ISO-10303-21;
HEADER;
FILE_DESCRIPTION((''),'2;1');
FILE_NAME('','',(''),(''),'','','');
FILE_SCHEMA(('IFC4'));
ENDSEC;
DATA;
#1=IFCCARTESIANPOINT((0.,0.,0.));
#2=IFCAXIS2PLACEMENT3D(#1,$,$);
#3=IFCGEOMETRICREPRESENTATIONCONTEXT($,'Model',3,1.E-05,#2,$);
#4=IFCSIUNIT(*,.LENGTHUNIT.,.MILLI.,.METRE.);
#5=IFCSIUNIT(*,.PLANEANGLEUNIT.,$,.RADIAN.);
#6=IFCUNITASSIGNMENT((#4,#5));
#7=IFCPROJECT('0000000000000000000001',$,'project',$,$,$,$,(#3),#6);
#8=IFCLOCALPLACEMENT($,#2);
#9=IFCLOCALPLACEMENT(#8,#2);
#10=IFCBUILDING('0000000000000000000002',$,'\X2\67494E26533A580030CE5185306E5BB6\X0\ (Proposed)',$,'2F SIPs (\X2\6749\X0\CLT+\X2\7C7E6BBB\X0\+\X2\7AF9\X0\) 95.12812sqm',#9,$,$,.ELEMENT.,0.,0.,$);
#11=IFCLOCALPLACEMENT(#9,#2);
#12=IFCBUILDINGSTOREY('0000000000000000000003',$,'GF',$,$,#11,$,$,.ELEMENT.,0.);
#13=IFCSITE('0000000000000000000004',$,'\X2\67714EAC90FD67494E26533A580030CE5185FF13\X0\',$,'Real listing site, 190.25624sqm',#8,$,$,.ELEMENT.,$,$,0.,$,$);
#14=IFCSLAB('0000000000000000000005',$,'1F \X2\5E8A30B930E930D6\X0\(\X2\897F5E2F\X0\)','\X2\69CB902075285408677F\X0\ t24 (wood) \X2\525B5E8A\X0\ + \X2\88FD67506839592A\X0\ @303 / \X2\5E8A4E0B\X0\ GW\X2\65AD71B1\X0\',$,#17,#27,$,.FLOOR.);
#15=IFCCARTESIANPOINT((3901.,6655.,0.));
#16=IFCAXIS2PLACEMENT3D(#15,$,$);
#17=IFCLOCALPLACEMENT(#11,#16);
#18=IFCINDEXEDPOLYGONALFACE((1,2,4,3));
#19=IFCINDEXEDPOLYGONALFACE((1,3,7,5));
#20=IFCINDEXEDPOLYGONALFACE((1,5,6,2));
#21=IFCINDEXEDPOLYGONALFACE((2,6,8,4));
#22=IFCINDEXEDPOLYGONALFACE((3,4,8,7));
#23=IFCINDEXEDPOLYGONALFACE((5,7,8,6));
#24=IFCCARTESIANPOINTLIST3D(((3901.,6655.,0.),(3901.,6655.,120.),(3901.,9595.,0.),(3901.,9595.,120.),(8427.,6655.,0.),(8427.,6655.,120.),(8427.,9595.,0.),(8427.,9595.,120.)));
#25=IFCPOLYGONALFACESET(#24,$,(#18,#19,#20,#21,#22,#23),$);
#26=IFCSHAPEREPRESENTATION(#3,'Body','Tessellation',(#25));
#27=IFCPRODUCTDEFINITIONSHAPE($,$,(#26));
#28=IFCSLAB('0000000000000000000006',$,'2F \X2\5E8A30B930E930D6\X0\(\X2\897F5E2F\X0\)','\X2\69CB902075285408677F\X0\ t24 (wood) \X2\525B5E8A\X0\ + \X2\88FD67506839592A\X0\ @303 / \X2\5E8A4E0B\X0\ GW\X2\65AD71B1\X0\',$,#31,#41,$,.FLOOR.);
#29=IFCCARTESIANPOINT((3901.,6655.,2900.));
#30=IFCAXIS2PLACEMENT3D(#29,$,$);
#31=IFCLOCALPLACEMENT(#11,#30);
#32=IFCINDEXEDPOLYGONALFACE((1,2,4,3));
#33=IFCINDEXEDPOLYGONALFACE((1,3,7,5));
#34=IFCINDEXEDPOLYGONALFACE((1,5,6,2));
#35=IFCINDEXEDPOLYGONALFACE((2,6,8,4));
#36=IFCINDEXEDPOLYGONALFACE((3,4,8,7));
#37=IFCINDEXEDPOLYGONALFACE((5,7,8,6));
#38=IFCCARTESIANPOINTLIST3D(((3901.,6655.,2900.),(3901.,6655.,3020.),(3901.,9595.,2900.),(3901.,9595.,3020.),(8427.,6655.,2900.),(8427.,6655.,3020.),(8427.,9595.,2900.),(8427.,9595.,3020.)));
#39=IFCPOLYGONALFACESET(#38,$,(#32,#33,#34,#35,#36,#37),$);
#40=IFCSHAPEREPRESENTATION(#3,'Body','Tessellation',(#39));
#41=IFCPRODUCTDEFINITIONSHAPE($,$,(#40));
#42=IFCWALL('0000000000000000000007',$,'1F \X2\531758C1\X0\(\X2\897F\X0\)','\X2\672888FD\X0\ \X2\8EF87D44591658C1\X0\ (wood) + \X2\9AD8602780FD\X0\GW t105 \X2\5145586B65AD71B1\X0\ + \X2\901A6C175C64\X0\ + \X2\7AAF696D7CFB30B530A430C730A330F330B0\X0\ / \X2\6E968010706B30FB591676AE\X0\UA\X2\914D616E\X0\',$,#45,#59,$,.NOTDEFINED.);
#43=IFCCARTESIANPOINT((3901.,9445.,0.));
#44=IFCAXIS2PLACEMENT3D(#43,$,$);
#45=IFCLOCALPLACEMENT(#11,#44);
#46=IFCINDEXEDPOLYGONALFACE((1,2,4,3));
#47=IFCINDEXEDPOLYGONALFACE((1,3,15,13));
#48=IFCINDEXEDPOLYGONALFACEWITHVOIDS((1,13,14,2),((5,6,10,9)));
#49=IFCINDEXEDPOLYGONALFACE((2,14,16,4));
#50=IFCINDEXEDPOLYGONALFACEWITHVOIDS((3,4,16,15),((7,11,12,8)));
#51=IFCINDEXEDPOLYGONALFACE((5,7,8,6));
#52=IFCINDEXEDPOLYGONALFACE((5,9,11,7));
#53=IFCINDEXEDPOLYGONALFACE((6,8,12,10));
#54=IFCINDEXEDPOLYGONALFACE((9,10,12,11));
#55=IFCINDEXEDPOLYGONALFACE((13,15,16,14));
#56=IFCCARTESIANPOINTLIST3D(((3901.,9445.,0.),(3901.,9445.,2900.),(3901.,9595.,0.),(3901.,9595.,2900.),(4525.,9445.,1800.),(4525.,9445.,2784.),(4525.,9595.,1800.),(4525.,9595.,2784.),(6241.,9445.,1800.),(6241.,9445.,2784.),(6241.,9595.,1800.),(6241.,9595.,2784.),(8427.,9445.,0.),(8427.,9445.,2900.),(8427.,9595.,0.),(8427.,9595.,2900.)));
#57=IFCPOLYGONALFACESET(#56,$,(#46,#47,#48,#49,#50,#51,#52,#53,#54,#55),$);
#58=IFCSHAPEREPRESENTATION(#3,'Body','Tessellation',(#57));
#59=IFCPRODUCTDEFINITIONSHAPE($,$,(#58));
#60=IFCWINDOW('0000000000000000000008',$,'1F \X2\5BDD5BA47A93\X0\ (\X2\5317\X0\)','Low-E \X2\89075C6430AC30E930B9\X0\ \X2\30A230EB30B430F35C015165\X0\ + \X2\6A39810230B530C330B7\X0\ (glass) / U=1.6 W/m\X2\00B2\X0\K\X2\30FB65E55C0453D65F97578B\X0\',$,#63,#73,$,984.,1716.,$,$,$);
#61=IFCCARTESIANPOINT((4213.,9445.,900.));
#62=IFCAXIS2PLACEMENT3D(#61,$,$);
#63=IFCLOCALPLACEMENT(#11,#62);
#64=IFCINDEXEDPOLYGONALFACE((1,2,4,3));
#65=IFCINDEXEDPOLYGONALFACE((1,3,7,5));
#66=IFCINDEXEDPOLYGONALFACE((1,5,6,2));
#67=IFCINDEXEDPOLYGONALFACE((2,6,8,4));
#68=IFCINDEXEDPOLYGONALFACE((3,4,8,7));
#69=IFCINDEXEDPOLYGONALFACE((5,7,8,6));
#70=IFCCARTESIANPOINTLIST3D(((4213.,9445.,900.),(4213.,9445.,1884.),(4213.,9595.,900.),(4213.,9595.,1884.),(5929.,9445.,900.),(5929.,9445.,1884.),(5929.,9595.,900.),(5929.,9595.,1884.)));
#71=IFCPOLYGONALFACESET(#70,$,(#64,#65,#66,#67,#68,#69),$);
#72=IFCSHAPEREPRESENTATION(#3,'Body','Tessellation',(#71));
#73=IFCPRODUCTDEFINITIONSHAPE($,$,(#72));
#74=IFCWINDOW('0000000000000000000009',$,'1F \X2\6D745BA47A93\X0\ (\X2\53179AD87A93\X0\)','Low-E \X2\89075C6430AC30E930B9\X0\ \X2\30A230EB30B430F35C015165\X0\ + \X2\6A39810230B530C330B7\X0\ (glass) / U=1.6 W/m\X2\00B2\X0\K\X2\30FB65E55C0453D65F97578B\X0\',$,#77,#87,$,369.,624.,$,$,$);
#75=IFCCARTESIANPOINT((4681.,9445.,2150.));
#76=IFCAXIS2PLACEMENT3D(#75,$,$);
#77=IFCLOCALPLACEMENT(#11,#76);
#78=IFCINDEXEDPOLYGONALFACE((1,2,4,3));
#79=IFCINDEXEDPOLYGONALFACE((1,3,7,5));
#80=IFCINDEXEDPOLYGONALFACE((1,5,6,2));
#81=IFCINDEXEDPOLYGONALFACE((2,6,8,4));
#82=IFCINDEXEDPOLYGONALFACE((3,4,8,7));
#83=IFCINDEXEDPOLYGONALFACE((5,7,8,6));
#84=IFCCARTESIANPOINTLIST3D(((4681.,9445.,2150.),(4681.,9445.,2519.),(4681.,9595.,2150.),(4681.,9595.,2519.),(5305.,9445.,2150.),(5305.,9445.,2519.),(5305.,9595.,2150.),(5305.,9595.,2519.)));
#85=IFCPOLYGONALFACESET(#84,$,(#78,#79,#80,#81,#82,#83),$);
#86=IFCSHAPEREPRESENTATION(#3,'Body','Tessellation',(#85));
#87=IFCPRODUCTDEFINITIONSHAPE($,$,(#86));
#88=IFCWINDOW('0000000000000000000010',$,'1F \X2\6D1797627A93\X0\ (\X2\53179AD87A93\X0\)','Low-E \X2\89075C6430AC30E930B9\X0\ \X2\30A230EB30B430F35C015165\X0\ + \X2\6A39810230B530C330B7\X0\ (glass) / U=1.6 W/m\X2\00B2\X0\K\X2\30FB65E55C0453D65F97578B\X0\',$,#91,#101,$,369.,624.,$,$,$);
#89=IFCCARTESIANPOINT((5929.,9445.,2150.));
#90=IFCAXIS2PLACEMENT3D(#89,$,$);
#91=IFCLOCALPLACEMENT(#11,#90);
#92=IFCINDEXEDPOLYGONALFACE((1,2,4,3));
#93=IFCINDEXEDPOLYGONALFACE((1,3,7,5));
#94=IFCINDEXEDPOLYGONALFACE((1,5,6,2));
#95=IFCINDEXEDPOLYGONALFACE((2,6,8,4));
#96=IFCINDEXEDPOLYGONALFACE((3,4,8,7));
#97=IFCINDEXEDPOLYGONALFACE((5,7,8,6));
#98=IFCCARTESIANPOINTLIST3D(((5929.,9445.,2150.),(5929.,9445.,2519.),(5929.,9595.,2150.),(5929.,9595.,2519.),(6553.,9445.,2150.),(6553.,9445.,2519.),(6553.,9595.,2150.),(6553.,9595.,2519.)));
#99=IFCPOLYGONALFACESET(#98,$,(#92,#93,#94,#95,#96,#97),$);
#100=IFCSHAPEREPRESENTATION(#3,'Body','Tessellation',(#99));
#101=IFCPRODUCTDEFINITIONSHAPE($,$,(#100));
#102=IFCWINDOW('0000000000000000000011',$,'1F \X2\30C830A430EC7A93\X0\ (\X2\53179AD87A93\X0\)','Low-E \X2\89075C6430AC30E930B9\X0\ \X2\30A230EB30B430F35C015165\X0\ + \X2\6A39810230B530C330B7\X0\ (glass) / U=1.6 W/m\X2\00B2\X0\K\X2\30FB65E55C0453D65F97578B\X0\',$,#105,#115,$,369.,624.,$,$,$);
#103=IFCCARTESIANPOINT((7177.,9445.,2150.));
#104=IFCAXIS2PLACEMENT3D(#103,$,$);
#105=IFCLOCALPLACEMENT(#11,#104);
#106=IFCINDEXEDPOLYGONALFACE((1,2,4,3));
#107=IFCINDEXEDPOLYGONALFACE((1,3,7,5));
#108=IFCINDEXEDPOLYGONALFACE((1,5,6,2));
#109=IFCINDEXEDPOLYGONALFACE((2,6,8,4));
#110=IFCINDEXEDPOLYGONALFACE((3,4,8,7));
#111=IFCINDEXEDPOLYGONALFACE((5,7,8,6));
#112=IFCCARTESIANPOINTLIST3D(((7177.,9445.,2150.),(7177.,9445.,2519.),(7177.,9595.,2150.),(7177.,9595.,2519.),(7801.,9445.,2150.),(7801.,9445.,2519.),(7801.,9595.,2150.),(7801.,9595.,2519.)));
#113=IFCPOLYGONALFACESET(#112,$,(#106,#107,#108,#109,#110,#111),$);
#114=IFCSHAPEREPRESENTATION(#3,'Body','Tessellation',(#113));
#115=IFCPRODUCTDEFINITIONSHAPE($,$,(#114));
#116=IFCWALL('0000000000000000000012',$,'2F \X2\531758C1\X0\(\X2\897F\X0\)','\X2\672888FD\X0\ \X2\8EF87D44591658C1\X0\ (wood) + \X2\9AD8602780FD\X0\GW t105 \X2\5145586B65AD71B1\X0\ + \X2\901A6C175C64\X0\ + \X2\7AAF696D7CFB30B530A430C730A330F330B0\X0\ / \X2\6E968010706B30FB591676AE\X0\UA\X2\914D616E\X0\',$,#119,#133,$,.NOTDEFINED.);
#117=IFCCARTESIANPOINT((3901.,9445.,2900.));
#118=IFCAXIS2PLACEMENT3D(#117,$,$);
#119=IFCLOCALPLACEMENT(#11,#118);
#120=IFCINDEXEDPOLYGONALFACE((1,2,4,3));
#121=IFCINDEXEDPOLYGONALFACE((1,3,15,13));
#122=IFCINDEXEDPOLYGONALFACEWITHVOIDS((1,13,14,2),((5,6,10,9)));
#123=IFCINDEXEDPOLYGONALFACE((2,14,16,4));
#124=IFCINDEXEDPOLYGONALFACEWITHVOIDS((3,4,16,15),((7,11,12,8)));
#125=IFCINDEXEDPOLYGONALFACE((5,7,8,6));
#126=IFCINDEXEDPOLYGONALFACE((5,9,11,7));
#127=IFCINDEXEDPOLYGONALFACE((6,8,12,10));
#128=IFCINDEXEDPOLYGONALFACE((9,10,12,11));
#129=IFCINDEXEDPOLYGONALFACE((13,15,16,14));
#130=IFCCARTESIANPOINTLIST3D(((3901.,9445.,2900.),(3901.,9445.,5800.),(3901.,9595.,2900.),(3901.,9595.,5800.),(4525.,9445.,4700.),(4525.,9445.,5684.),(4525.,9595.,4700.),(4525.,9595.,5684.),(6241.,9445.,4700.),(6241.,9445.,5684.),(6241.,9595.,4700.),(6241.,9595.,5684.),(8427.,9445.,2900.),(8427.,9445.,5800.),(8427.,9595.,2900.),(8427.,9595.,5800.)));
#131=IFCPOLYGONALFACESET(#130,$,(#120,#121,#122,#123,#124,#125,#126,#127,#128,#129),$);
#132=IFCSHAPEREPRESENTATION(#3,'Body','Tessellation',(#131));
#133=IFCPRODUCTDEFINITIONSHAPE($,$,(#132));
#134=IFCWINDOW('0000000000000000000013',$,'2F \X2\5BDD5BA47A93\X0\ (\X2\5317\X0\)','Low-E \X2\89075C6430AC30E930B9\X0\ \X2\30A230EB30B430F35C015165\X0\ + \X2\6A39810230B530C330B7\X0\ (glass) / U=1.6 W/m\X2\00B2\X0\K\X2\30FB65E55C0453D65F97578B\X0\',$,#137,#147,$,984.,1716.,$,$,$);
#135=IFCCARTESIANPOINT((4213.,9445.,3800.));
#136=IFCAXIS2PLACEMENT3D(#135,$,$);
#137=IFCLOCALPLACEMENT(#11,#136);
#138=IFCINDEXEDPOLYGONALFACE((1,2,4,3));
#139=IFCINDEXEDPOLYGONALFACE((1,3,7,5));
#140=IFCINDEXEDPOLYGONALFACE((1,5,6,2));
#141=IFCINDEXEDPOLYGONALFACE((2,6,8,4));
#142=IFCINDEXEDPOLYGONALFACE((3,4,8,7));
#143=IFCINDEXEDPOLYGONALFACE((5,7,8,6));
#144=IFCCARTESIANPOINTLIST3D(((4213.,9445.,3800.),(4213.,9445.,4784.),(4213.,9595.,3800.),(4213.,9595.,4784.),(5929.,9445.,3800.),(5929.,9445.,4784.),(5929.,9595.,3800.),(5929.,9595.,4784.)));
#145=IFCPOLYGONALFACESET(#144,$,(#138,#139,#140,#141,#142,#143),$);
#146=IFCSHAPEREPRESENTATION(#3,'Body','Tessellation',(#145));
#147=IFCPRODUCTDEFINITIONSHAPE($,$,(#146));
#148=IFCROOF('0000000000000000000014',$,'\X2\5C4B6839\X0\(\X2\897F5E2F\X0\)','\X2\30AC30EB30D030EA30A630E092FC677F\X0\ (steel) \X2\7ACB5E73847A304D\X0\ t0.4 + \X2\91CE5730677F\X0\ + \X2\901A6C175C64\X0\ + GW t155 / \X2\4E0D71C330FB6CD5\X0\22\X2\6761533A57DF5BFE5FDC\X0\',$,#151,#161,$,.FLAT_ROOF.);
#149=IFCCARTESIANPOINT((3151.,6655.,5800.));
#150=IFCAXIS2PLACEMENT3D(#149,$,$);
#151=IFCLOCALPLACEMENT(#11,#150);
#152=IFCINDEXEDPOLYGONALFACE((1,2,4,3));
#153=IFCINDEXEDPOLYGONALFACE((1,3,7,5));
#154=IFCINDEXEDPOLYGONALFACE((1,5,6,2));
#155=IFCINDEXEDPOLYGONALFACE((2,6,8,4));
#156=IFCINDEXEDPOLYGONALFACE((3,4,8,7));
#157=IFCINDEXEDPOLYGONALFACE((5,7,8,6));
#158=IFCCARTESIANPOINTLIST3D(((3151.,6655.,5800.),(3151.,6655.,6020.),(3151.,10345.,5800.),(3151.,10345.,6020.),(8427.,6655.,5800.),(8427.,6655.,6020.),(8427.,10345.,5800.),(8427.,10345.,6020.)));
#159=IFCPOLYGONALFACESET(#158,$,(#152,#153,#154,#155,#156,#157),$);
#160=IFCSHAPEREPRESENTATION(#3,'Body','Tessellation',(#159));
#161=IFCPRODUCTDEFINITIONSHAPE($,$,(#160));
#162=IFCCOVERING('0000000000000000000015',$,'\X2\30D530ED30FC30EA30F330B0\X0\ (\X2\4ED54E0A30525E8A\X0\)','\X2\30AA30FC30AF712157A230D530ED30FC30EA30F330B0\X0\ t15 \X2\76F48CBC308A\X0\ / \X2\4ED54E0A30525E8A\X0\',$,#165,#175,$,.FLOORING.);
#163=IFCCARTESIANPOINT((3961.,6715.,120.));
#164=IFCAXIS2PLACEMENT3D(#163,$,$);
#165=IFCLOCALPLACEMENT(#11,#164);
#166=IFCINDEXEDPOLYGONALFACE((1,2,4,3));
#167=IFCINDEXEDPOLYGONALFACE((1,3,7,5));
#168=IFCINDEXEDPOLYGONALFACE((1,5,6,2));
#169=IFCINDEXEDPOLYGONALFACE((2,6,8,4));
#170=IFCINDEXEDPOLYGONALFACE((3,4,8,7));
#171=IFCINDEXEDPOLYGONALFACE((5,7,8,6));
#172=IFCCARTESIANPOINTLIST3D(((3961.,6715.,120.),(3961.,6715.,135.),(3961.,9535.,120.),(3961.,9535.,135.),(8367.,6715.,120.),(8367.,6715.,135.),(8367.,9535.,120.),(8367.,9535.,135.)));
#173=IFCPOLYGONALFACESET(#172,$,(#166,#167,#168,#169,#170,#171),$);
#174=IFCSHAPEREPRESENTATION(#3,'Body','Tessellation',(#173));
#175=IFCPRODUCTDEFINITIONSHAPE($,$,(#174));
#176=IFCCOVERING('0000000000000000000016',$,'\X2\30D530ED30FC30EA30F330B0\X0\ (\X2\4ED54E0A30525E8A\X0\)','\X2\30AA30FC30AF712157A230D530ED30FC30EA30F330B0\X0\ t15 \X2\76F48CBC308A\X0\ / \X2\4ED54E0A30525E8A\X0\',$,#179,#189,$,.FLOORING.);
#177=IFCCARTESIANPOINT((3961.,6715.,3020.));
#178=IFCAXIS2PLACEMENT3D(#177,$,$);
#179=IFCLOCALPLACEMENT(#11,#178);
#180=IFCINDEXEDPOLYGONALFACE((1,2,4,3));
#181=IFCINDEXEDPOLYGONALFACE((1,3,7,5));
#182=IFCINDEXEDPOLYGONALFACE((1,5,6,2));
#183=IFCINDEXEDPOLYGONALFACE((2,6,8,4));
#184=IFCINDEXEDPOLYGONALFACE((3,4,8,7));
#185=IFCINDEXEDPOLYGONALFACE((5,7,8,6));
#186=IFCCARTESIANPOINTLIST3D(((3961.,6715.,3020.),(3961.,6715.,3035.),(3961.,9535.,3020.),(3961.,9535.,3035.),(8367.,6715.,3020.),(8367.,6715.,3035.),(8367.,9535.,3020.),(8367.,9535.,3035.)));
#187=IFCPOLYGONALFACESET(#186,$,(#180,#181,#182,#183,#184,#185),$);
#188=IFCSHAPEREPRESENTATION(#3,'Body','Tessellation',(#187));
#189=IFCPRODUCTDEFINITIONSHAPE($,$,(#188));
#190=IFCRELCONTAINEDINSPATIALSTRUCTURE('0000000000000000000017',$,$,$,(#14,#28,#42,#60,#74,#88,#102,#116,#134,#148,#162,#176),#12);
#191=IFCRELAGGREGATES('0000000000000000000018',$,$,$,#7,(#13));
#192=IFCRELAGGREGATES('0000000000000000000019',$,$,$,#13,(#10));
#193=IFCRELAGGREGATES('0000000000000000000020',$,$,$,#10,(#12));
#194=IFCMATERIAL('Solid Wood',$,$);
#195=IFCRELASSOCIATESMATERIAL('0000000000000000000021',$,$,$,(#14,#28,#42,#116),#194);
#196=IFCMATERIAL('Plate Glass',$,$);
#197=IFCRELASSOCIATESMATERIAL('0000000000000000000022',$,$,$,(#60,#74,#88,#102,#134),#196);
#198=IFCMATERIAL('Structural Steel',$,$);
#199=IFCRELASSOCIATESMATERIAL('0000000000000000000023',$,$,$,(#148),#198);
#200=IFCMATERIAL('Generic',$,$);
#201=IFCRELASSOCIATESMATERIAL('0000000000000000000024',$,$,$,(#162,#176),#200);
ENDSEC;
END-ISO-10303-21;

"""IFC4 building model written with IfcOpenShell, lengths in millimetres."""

from ifc_helpers import new_model, si_unit, frame, frame_2d, origin, place, context, project, spatial, rectangle, extrude, material, element, fill, save


model = new_model("IFC4")

# Units and contexts
model_context = context("Model", 3, precision=1e-05, world=origin())
ifc_project = project(units=[si_unit("LENGTHUNIT", "METRE", prefix="MILLI"), si_unit("PLANEANGLEUNIT", "RADIAN")], contexts=[model_context])

# Site, building, storey
site_placement = place(None, origin())
site = spatial("IfcSite", under=ifc_project, at=site_placement, Name="東京都杉並区堀ノ内３", ObjectType="Real listing site, 190.25624sqm", CompositionType="ELEMENT", RefElevation=0.0)
building_placement = place(site_placement, origin())
building = spatial("IfcBuilding", under=site, at=building_placement, Name="杉並区堀ノ内の家 (Proposed)", ObjectType="2F SIPs (杉CLT+籾殻+竹) 95.12812sqm", CompositionType="ELEMENT", ElevationOfRefHeight=0.0, ElevationOfTerrain=0.0)
storey_placement = place(building_placement, origin())
storey = spatial("IfcBuildingStorey", under=building, at=storey_placement, Name="GF", CompositionType="ELEMENT", Elevation=0.0)

# Slabs
ifc_material_1 = material(Name="Solid Wood")
slab_1_placement = place(storey_placement, frame((3901.0, 6655.0, 0.0)))
element("IfcSlab", 1, at=slab_1_placement, inside=storey, material=ifc_material_1, Name="1F 床スラブ(西帯)", Description="構造用合板 t24 (wood) 剛床 + 製材根太 @303 / 床下 GW断熱", PredefinedType="FLOOR", context=model_context, shape_type="SweptSolid", body=[
    extrude(rectangle(XDim=4526.0, YDim=2940.0, at=frame_2d((2263.0, 1470.0))), frame((3901.0, 6655.0, 0.0)), (0.0, 0.0, 1.0), 120.0),
])
slab_2_placement = place(storey_placement, frame((3901.0, 6655.0, 2900.0)))
element("IfcSlab", 2, at=slab_2_placement, inside=storey, material=ifc_material_1, Name="2F 床スラブ(西帯)", Description="構造用合板 t24 (wood) 剛床 + 製材根太 @303 / 床下 GW断熱", PredefinedType="FLOOR", context=model_context, shape_type="SweptSolid", body=[
    extrude(rectangle(XDim=4526.0, YDim=2940.0, at=frame_2d((2263.0, 1470.0))), frame((3901.0, 6655.0, 2900.0)), (0.0, 0.0, 1.0), 120.0),
])

# Wall, openings, windows
wall_1_placement = place(storey_placement, frame((3901.0, 9445.0, 0.0)))
wall_1 = element("IfcWall", 3, at=wall_1_placement, inside=storey, material=ifc_material_1, Name="1F 北壁(西)", Description="木製 軸組外壁 (wood) + 高性能GW t105 充填断熱 + 通気層 + 窯業系サイディング / 準耐火・外皮UA配慮", PredefinedType="NOTDEFINED", context=model_context, shape_type="SweptSolid", body=[
    extrude(rectangle(XDim=4526.0, YDim=150.0, at=frame_2d((2263.0, 75.0))), frame((3901.0, 9445.0, 0.0)), (0.0, 0.0, 1.0), 2900.0),
])
opening_1_placement = place(storey_placement, frame((4213.0, 9445.0, 900.0)))
opening_1 = element("IfcOpeningElement", 4, at=opening_1_placement, cuts=wall_1, PredefinedType="NOTDEFINED", context=model_context, shape_type="SweptSolid", body=[
    extrude(rectangle(XDim=1716.0, YDim=150.0, at=frame_2d((858.0, 75.0))), frame((4213.0, 9445.0, 900.0)), (0.0, 0.0, 1.0), 984.0),
])
opening_2_placement = place(storey_placement, frame((4681.0, 9445.0, 2150.0)))
opening_2 = element("IfcOpeningElement", 5, at=opening_2_placement, cuts=wall_1, PredefinedType="NOTDEFINED", context=model_context, shape_type="SweptSolid", body=[
    extrude(rectangle(XDim=624.0, YDim=150.0, at=frame_2d((312.0, 75.0))), frame((4681.0, 9445.0, 2150.0)), (0.0, 0.0, 1.0), 369.0),
])
opening_3_placement = place(storey_placement, frame((5929.0, 9445.0, 2150.0)))
opening_3 = element("IfcOpeningElement", 6, at=opening_3_placement, cuts=wall_1, PredefinedType="NOTDEFINED", context=model_context, shape_type="SweptSolid", body=[
    extrude(rectangle(XDim=624.0, YDim=150.0, at=frame_2d((312.0, 75.0))), frame((5929.0, 9445.0, 2150.0)), (0.0, 0.0, 1.0), 369.0),
])
opening_4_placement = place(storey_placement, frame((7177.0, 9445.0, 2150.0)))
opening_4 = element("IfcOpeningElement", 7, at=opening_4_placement, cuts=wall_1, PredefinedType="NOTDEFINED", context=model_context, shape_type="SweptSolid", body=[
    extrude(rectangle(XDim=624.0, YDim=150.0, at=frame_2d((312.0, 75.0))), frame((7177.0, 9445.0, 2150.0)), (0.0, 0.0, 1.0), 369.0),
])
ifc_material_2 = material(Name="Plate Glass")
window_1_placement = place(storey_placement, frame((4213.0, 9445.0, 900.0)))
window_1 = element("IfcWindow", 8, at=window_1_placement, inside=storey, material=ifc_material_2, Name="1F 寝室窓 (北)", Description="Low-E 複層ガラス アルゴン封入 + 樹脂サッシ (glass) / U=1.6 W/m²K・日射取得型", OverallHeight=984.0, OverallWidth=1716.0, context=model_context, shape_type="SweptSolid", body=[
    extrude(rectangle(XDim=1716.0, YDim=150.0, at=frame_2d((858.0, 75.0))), frame((4213.0, 9445.0, 900.0)), (0.0, 0.0, 1.0), 984.0),
])
fill(opening_1, window_1)
window_2_placement = place(storey_placement, frame((4681.0, 9445.0, 2150.0)))
window_2 = element("IfcWindow", 9, at=window_2_placement, inside=storey, material=ifc_material_2, Name="1F 浴室窓 (北高窓)", Description="Low-E 複層ガラス アルゴン封入 + 樹脂サッシ (glass) / U=1.6 W/m²K・日射取得型", OverallHeight=369.0, OverallWidth=624.0, context=model_context, shape_type="SweptSolid", body=[
    extrude(rectangle(XDim=624.0, YDim=150.0, at=frame_2d((312.0, 75.0))), frame((4681.0, 9445.0, 2150.0)), (0.0, 0.0, 1.0), 369.0),
])
fill(opening_2, window_2)
window_3_placement = place(storey_placement, frame((5929.0, 9445.0, 2150.0)))
window_3 = element("IfcWindow", 10, at=window_3_placement, inside=storey, material=ifc_material_2, Name="1F 洗面窓 (北高窓)", Description="Low-E 複層ガラス アルゴン封入 + 樹脂サッシ (glass) / U=1.6 W/m²K・日射取得型", OverallHeight=369.0, OverallWidth=624.0, context=model_context, shape_type="SweptSolid", body=[
    extrude(rectangle(XDim=624.0, YDim=150.0, at=frame_2d((312.0, 75.0))), frame((5929.0, 9445.0, 2150.0)), (0.0, 0.0, 1.0), 369.0),
])
fill(opening_3, window_3)
window_4_placement = place(storey_placement, frame((7177.0, 9445.0, 2150.0)))
window_4 = element("IfcWindow", 11, at=window_4_placement, inside=storey, material=ifc_material_2, Name="1F トイレ窓 (北高窓)", Description="Low-E 複層ガラス アルゴン封入 + 樹脂サッシ (glass) / U=1.6 W/m²K・日射取得型", OverallHeight=369.0, OverallWidth=624.0, context=model_context, shape_type="SweptSolid", body=[
    extrude(rectangle(XDim=624.0, YDim=150.0, at=frame_2d((312.0, 75.0))), frame((7177.0, 9445.0, 2150.0)), (0.0, 0.0, 1.0), 369.0),
])
fill(opening_4, window_4)

# Wall, opening, window
wall_2_placement = place(storey_placement, frame((3901.0, 9445.0, 2900.0)))
wall_2 = element("IfcWall", 12, at=wall_2_placement, inside=storey, material=ifc_material_1, Name="2F 北壁(西)", Description="木製 軸組外壁 (wood) + 高性能GW t105 充填断熱 + 通気層 + 窯業系サイディング / 準耐火・外皮UA配慮", PredefinedType="NOTDEFINED", context=model_context, shape_type="SweptSolid", body=[
    extrude(rectangle(XDim=4526.0, YDim=150.0, at=frame_2d((2263.0, 75.0))), frame((3901.0, 9445.0, 2900.0)), (0.0, 0.0, 1.0), 2900.0),
])
opening_5_placement = place(storey_placement, frame((4213.0, 9445.0, 3800.0)))
opening_5 = element("IfcOpeningElement", 13, at=opening_5_placement, cuts=wall_2, PredefinedType="NOTDEFINED", context=model_context, shape_type="SweptSolid", body=[
    extrude(rectangle(XDim=1716.0, YDim=150.0, at=frame_2d((858.0, 75.0))), frame((4213.0, 9445.0, 3800.0)), (0.0, 0.0, 1.0), 984.0),
])
window_5_placement = place(storey_placement, frame((4213.0, 9445.0, 3800.0)))
window_5 = element("IfcWindow", 14, at=window_5_placement, inside=storey, material=ifc_material_2, Name="2F 寝室窓 (北)", Description="Low-E 複層ガラス アルゴン封入 + 樹脂サッシ (glass) / U=1.6 W/m²K・日射取得型", OverallHeight=984.0, OverallWidth=1716.0, context=model_context, shape_type="SweptSolid", body=[
    extrude(rectangle(XDim=1716.0, YDim=150.0, at=frame_2d((858.0, 75.0))), frame((4213.0, 9445.0, 3800.0)), (0.0, 0.0, 1.0), 984.0),
])
fill(opening_5, window_5)

# Roof
ifc_material_3 = material(Name="Structural Steel")
for number, where, name in (
    (15, (3151.0, 6655.0, 5800.0), "屋根(西帯)"),
):
    element("IfcRoof", number, at=place(storey_placement, frame(where)), inside=storey, material=ifc_material_3, Name=name, Description="ガルバリウム鋼板 (steel) 立平葺き t0.4 + 野地板 + 通気層 + GW t155 / 不燃・法22条区域対応", PredefinedType="FLAT_ROOF", context=model_context, shape_type="SweptSolid", body=[
        extrude(rectangle(XDim=5276.0, YDim=3690.0, at=frame_2d((2638.0, 1845.0))), frame((3151.0, 6655.0, 5800.0)), (0.0, 0.0, 1.0), 220.0),
    ])

# Coverings
ifc_material_4 = material(Name="Generic")
covering_1_placement = place(storey_placement, frame((3961.0, 6715.0, 120.0)))
element("IfcCovering", 16, at=covering_1_placement, inside=storey, material=ifc_material_4, Name="フローリング (仕上げ床)", Description="オーク無垢フローリング t15 直貼り / 仕上げ床", PredefinedType="FLOORING", context=model_context, shape_type="SweptSolid", body=[
    extrude(rectangle(XDim=4406.0, YDim=2820.0, at=frame_2d((2203.0, 1410.0))), frame((3961.0, 6715.0, 120.0)), (0.0, 0.0, 1.0), 15.0),
])
covering_2_placement = place(storey_placement, frame((3961.0, 6715.0, 3020.0)))
element("IfcCovering", 17, at=covering_2_placement, inside=storey, material=ifc_material_4, Name="フローリング (仕上げ床)", Description="オーク無垢フローリング t15 直貼り / 仕上げ床", PredefinedType="FLOORING", context=model_context, shape_type="SweptSolid", body=[
    extrude(rectangle(XDim=4406.0, YDim=2820.0, at=frame_2d((2203.0, 1410.0))), frame((3961.0, 6715.0, 3020.0)), (0.0, 0.0, 1.0), 15.0),
])

save(model, "model.ifc")
